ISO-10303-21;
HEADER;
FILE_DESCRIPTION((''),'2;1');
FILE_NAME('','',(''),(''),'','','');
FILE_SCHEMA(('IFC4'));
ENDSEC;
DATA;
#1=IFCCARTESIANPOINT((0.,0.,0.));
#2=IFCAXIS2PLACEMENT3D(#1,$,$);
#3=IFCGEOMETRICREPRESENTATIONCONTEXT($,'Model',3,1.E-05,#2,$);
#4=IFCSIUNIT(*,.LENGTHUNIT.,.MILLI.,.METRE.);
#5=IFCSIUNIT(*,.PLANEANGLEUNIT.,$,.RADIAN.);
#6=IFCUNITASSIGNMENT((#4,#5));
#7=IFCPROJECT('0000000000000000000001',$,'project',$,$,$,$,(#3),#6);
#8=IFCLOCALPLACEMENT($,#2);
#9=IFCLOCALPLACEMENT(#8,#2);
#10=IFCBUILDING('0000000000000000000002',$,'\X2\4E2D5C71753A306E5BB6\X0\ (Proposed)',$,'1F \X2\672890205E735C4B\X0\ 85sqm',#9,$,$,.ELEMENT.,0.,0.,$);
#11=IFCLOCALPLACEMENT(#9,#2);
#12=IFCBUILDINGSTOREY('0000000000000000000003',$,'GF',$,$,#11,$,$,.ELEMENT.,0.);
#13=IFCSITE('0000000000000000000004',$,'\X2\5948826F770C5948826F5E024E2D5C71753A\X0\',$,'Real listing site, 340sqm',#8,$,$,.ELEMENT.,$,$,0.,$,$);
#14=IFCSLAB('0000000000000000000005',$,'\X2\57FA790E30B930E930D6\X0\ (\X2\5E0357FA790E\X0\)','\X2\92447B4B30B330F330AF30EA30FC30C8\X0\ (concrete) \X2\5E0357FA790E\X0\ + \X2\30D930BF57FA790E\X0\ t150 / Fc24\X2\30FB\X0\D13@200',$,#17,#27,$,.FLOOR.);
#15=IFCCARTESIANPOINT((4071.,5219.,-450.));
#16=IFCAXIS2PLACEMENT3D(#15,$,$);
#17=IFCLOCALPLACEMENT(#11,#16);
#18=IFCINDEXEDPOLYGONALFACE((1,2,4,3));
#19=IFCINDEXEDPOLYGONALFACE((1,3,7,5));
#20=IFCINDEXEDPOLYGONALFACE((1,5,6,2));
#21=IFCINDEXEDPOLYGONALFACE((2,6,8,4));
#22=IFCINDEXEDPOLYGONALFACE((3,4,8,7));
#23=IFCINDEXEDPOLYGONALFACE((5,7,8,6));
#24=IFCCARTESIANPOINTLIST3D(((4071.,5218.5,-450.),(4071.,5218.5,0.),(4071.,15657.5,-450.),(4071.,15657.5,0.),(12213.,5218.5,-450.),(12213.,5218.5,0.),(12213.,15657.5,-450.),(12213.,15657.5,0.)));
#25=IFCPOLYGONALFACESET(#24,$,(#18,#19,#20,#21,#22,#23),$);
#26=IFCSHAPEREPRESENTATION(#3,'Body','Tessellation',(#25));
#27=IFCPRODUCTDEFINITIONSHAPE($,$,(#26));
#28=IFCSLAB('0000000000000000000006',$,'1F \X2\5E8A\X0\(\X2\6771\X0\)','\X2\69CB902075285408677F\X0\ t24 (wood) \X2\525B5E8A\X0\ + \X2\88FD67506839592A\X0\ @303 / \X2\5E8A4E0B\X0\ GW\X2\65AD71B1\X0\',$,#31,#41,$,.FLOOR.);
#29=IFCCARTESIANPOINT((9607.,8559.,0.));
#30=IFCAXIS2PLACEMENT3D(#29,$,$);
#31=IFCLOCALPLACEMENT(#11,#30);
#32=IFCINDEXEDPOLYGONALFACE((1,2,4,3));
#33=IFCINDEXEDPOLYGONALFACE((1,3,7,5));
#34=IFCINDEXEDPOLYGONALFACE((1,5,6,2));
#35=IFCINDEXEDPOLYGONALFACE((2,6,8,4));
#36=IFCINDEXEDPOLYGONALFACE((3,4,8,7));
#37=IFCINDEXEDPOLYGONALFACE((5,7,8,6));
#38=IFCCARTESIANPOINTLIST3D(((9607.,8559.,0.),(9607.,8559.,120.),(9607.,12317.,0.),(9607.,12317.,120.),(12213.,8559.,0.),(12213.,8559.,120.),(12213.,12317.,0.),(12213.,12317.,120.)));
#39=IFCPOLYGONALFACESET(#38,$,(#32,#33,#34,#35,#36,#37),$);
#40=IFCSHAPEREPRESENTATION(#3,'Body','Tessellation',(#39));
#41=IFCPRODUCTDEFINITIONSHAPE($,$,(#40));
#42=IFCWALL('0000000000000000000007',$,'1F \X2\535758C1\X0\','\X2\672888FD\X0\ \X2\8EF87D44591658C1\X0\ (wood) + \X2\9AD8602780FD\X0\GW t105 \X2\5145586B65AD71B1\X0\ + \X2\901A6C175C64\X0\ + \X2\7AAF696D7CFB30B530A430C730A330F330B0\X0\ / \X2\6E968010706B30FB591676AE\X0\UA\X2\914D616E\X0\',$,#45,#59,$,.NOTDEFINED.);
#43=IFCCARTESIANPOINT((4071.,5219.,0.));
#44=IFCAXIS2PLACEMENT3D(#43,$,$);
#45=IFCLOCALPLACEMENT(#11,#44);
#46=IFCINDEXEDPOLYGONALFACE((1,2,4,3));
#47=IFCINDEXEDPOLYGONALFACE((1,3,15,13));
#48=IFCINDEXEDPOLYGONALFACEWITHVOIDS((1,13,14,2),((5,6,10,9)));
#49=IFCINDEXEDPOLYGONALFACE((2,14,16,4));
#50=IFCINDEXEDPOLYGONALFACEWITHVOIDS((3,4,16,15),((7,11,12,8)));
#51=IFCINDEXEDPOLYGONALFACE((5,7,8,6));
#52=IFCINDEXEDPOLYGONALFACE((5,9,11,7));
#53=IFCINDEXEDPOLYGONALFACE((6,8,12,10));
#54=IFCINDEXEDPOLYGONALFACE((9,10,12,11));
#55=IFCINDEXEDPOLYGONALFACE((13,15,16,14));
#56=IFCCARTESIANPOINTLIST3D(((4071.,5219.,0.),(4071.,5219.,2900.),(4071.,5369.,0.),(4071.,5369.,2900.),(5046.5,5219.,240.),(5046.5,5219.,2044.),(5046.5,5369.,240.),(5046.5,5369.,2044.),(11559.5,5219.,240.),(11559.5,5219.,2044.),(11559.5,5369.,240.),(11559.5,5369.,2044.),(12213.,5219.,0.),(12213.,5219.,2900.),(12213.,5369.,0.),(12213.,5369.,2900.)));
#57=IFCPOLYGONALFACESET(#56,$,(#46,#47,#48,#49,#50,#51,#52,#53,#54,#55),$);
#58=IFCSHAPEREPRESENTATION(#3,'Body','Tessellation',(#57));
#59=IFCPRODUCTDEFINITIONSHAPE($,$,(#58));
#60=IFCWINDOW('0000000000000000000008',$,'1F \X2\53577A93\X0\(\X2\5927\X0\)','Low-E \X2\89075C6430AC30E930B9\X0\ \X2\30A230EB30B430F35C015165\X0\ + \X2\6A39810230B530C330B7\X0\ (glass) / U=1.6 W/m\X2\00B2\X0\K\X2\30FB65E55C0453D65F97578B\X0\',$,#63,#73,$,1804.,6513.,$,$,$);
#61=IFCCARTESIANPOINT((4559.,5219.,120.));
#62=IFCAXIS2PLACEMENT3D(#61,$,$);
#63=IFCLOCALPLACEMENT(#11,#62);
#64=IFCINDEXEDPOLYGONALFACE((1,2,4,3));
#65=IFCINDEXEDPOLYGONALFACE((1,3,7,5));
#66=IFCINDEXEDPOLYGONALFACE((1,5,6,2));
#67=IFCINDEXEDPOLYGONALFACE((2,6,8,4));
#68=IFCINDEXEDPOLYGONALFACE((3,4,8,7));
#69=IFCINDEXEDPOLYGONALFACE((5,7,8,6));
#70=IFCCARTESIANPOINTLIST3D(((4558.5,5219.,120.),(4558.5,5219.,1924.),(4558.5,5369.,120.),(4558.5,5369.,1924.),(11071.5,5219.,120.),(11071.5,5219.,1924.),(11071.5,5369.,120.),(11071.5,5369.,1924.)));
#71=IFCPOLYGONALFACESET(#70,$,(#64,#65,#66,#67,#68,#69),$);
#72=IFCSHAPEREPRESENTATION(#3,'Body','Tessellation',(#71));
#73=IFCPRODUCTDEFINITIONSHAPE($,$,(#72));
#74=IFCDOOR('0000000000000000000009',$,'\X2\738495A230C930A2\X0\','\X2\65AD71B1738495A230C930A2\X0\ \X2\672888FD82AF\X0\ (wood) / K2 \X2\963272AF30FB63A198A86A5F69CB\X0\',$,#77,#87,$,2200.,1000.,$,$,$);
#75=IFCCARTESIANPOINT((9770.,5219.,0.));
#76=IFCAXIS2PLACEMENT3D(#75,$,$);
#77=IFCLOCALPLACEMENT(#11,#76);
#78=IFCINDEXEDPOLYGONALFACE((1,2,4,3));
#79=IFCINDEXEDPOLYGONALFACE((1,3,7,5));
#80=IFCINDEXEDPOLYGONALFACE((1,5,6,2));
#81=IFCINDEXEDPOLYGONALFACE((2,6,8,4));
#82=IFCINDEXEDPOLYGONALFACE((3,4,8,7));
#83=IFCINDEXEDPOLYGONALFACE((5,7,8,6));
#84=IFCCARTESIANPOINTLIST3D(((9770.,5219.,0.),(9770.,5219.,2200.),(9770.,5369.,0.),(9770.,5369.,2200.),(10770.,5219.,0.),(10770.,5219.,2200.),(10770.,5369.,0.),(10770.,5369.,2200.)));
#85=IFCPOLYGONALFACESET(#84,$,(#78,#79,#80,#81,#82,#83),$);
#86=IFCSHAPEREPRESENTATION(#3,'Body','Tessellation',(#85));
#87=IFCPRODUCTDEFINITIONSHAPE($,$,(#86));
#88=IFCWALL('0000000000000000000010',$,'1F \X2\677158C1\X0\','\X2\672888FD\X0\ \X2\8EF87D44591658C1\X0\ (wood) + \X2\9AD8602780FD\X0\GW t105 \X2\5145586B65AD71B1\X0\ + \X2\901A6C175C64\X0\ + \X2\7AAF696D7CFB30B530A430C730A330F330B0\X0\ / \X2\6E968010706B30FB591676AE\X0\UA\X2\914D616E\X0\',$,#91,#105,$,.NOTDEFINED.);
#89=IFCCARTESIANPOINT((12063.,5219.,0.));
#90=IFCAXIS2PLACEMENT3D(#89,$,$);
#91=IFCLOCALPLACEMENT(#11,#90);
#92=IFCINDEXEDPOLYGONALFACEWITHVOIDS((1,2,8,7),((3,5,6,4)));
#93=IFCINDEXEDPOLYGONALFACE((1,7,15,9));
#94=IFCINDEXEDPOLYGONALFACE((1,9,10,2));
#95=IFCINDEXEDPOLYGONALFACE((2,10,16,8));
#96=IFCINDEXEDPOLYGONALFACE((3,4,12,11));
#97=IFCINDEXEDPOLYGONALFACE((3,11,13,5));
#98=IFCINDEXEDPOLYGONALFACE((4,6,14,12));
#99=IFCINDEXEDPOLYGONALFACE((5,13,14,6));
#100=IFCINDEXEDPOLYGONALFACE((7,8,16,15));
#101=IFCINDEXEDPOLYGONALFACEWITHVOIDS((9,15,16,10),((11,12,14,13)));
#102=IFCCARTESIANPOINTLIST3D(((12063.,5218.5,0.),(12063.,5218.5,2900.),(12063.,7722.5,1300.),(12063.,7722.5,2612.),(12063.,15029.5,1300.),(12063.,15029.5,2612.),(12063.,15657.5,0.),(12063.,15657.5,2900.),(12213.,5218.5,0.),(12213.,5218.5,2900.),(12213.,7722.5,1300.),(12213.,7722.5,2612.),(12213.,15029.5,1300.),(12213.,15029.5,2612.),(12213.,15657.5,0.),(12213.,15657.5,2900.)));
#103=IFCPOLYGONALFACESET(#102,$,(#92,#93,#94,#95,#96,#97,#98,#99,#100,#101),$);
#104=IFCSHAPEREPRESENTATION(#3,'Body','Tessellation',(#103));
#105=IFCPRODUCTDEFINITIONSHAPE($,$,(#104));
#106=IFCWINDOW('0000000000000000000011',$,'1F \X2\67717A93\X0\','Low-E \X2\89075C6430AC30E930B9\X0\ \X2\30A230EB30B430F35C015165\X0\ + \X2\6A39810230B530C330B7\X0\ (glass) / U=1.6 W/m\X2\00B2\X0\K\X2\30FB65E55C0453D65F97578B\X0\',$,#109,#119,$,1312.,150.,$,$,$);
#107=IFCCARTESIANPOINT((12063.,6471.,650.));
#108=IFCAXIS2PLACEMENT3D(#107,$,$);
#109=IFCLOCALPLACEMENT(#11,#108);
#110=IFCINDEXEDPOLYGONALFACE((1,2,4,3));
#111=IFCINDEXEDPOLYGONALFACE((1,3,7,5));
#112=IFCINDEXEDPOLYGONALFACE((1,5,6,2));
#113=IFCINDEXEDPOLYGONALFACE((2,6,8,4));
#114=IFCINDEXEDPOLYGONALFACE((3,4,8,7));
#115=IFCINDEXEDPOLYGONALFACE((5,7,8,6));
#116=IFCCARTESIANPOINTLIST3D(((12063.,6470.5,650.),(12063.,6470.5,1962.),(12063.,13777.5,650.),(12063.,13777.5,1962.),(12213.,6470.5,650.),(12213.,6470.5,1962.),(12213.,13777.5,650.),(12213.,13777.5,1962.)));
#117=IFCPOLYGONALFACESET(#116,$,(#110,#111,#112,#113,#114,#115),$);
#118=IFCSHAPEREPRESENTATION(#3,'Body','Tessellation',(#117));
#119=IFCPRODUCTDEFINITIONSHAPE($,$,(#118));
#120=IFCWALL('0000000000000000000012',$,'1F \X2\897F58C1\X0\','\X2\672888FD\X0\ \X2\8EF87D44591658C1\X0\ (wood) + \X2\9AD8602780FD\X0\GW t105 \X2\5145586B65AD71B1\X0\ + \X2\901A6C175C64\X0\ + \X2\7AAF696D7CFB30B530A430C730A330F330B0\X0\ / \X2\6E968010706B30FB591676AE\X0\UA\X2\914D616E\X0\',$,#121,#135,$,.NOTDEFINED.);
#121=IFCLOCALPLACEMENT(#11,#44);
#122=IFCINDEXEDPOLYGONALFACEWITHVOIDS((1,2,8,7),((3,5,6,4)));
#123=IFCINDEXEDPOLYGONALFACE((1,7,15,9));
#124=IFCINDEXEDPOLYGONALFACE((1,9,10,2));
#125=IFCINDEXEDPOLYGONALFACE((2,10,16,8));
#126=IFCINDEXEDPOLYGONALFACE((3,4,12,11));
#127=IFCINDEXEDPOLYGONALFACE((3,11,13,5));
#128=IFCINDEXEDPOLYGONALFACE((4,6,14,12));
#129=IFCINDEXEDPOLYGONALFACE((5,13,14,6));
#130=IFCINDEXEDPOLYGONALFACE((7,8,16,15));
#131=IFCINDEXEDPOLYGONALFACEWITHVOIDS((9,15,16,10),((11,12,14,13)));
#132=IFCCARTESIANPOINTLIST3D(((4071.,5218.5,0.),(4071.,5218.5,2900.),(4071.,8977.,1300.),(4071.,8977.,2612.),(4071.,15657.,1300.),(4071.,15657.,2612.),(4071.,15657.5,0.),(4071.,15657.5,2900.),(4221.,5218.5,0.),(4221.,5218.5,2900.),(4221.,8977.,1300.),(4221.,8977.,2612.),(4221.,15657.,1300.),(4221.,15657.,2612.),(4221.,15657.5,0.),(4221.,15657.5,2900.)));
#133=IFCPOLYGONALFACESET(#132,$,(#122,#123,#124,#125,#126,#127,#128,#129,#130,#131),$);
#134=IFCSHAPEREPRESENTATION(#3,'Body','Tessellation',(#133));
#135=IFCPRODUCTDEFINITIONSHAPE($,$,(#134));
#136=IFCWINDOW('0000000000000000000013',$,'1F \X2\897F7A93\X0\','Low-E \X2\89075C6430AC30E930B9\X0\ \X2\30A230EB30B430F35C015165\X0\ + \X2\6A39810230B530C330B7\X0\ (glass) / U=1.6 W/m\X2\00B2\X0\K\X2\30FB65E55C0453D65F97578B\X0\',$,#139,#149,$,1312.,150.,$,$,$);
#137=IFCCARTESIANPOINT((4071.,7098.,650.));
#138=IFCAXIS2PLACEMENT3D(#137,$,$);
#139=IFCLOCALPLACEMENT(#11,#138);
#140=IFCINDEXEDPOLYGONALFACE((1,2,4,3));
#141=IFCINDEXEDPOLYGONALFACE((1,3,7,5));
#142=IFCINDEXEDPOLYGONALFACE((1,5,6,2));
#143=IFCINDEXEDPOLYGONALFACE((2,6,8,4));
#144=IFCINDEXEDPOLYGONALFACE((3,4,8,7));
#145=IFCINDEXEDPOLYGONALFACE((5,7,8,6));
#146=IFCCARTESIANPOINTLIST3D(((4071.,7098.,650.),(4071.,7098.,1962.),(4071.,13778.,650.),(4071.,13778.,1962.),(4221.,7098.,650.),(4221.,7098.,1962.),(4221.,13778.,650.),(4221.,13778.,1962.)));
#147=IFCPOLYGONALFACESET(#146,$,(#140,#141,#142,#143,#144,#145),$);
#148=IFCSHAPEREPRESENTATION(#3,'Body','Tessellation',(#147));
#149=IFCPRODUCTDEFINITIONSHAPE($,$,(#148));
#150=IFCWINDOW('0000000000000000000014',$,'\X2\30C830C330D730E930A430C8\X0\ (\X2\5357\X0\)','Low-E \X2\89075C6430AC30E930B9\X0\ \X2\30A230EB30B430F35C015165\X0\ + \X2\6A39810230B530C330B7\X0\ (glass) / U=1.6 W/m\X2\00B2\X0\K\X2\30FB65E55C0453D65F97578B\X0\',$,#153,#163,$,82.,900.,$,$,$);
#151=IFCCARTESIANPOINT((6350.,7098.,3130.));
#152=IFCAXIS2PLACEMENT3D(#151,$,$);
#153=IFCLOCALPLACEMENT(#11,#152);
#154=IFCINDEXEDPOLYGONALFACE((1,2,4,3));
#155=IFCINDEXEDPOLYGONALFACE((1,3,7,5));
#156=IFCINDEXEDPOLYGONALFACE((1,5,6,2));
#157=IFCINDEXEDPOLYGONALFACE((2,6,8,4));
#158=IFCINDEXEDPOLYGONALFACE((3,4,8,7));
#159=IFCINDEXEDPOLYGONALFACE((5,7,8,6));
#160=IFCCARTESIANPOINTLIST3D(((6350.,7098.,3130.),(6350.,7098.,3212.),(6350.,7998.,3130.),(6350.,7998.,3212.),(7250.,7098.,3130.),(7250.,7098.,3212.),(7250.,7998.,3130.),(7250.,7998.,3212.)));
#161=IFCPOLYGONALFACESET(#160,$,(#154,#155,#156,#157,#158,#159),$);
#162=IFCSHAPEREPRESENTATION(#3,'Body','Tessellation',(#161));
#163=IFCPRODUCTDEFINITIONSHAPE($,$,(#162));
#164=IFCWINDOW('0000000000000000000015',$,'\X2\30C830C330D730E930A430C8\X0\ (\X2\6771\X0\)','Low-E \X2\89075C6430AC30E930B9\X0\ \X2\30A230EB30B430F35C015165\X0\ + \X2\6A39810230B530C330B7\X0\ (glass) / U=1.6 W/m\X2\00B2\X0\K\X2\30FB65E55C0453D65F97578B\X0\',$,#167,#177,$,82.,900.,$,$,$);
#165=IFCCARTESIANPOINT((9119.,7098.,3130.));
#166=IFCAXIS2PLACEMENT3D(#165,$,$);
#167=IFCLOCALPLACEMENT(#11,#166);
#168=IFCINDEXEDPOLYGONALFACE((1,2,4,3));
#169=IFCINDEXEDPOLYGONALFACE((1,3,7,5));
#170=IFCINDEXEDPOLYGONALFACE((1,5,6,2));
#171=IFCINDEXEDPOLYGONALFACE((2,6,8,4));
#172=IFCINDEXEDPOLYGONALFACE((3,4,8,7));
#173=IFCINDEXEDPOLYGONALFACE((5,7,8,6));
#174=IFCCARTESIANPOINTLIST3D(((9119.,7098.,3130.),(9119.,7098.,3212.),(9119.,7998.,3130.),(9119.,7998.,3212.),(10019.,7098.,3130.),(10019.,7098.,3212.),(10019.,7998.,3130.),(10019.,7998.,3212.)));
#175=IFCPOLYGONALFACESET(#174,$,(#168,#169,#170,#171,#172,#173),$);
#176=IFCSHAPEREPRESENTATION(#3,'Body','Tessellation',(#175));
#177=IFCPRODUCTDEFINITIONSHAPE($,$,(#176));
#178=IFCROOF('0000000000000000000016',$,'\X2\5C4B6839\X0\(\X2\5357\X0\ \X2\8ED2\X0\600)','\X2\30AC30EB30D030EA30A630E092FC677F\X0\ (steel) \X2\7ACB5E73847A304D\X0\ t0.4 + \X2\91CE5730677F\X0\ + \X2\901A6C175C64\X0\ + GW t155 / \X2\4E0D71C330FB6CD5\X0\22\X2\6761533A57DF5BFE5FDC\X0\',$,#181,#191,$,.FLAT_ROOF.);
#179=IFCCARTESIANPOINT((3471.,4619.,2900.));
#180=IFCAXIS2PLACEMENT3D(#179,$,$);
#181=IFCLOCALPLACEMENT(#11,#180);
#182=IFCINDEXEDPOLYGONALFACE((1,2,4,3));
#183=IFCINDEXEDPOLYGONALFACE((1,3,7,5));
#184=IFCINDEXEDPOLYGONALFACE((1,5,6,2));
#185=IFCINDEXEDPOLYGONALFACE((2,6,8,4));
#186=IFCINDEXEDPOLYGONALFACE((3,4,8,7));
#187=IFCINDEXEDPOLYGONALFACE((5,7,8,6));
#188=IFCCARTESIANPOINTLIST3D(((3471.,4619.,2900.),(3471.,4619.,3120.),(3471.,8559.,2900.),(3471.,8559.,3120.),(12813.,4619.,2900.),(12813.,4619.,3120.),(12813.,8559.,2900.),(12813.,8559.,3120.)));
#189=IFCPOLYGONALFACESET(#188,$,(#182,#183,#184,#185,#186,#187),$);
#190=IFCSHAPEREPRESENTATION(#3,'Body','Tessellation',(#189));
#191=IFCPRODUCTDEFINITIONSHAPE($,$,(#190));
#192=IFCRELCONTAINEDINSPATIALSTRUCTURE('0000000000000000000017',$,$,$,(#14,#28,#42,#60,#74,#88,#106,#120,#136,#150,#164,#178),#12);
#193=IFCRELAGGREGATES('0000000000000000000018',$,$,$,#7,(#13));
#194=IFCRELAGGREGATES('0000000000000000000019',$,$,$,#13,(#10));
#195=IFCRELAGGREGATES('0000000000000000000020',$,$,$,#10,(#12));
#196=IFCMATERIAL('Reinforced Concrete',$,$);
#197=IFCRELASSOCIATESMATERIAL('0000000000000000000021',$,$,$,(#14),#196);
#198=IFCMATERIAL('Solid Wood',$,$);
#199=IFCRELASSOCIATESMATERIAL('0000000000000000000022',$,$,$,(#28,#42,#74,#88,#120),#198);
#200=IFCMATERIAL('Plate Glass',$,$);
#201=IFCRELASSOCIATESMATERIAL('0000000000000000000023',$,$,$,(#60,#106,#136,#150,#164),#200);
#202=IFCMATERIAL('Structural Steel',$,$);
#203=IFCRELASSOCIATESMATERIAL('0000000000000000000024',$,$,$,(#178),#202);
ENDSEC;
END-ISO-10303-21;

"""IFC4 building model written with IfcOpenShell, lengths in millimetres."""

from ifc_helpers import new_model, si_unit, frame, frame_2d, origin, place, context, project, spatial, rectangle, extrude, material, element, fill, save


model = new_model("IFC4")

# Units and contexts
model_context = context("Model", 3, precision=1e-05, world=origin())
ifc_project = project(units=[si_unit("LENGTHUNIT", "METRE", prefix="MILLI"), si_unit("PLANEANGLEUNIT", "RADIAN")], contexts=[model_context])

# Site, building, storey
site_placement = place(None, origin())
site = spatial("IfcSite", under=ifc_project, at=site_placement, Name="奈良県奈良市中山町", ObjectType="Real listing site, 340sqm", CompositionType="ELEMENT", RefElevation=0.0)
building_placement = place(site_placement, origin())
building = spatial("IfcBuilding", under=site, at=building_placement, Name="中山町の家 (Proposed)", ObjectType="1F 木造平屋 85sqm", CompositionType="ELEMENT", ElevationOfRefHeight=0.0, ElevationOfTerrain=0.0)
storey_placement = place(building_placement, origin())
storey = spatial("IfcBuildingStorey", under=building, at=storey_placement, Name="GF", CompositionType="ELEMENT", Elevation=0.0)

# Slabs
ifc_material_1 = material(Name="Reinforced Concrete")
slab_1_placement = place(storey_placement, frame((4071.0, 5219.0, -450.0)))
element("IfcSlab", 1, at=slab_1_placement, inside=storey, material=ifc_material_1, Name="基礎スラブ (布基礎)", Description="鉄筋コンクリート (concrete) 布基礎 + ベタ基礎 t150 / Fc24・D13@200", PredefinedType="FLOOR", context=model_context, shape_type="SweptSolid", body=[
    extrude(rectangle(XDim=8142.0, YDim=10439.0, at=frame_2d((4071.0, 5219.0))), frame((4071.0, 5219.0, -450.0)), (0.0, 0.0, 1.0), 450.0),
])
ifc_material_2 = material(Name="Solid Wood")
slab_2_placement = place(storey_placement, frame((9607.0, 8559.0, 0.0)))
element("IfcSlab", 2, at=slab_2_placement, inside=storey, material=ifc_material_2, Name="1F 床(東)", Description="構造用合板 t24 (wood) 剛床 + 製材根太 @303 / 床下 GW断熱", PredefinedType="FLOOR", context=model_context, shape_type="SweptSolid", body=[
    extrude(rectangle(XDim=2606.0, YDim=3758.0, at=frame_2d((1303.0, 1879.0))), frame((9607.0, 8559.0, 0.0)), (0.0, 0.0, 1.0), 120.0),
])

# Wall, openings, window, door
wall_1_placement = place(storey_placement, frame((4071.0, 5219.0, 0.0)))
wall_1 = element("IfcWall", 3, at=wall_1_placement, inside=storey, material=ifc_material_2, Name="1F 南壁", Description="木製 軸組外壁 (wood) + 高性能GW t105 充填断熱 + 通気層 + 窯業系サイディング / 準耐火・外皮UA配慮", PredefinedType="NOTDEFINED", context=model_context, shape_type="SweptSolid", body=[
    extrude(rectangle(XDim=8142.0, YDim=150.0, at=frame_2d((4071.0, 75.0))), frame((4071.0, 5219.0, 0.0)), (0.0, 0.0, 1.0), 2900.0),
])
opening_1_placement = place(storey_placement, frame((4559.0, 5219.0, 120.0)))
opening_1 = element("IfcOpeningElement", 4, at=opening_1_placement, cuts=wall_1, PredefinedType="NOTDEFINED", context=model_context, shape_type="SweptSolid", body=[
    extrude(rectangle(XDim=6513.0, YDim=150.0, at=frame_2d((3256.0, 75.0))), frame((4559.0, 5219.0, 120.0)), (0.0, 0.0, 1.0), 1804.0),
])
opening_2_placement = place(storey_placement, frame((9770.0, 5219.0, 0.0)))
opening_2 = element("IfcOpeningElement", 5, at=opening_2_placement, cuts=wall_1, PredefinedType="NOTDEFINED", context=model_context, shape_type="SweptSolid", body=[
    extrude(rectangle(XDim=1000.0, YDim=150.0, at=frame_2d((500.0, 75.0))), frame((9770.0, 5219.0, 0.0)), (0.0, 0.0, 1.0), 2200.0),
])
ifc_material_3 = material(Name="Plate Glass")
window_1_placement = place(storey_placement, frame((4559.0, 5219.0, 120.0)))
window_1 = element("IfcWindow", 6, at=window_1_placement, inside=storey, material=ifc_material_3, Name="1F 南窓(大)", Description="Low-E 複層ガラス アルゴン封入 + 樹脂サッシ (glass) / U=1.6 W/m²K・日射取得型", OverallHeight=1804.0, OverallWidth=6513.0, context=model_context, shape_type="SweptSolid", body=[
    extrude(rectangle(XDim=6513.0, YDim=150.0, at=frame_2d((3256.0, 75.0))), frame((4559.0, 5219.0, 120.0)), (0.0, 0.0, 1.0), 1804.0),
])
fill(opening_1, window_1)
door_placement = place(storey_placement, frame((9770.0, 5219.0, 0.0)))
door = element("IfcDoor", 7, at=door_placement, inside=storey, material=ifc_material_2, Name="玄関ドア", Description="断熱玄関ドア 木製芯 (wood) / K2 防犯・採風機構", OverallHeight=2200.0, OverallWidth=1000.0, context=model_context, shape_type="SweptSolid", body=[
    extrude(rectangle(XDim=1000.0, YDim=150.0, at=frame_2d((500.0, 75.0))), frame((9770.0, 5219.0, 0.0)), (0.0, 0.0, 1.0), 2200.0),
])
fill(opening_2, door)

# Walls, openings, windows
wall_2_placement = place(storey_placement, frame((12063.0, 5219.0, 0.0)))
wall_2 = element("IfcWall", 8, at=wall_2_placement, inside=storey, material=ifc_material_2, Name="1F 東壁", Description="木製 軸組外壁 (wood) + 高性能GW t105 充填断熱 + 通気層 + 窯業系サイディング / 準耐火・外皮UA配慮", PredefinedType="NOTDEFINED", context=model_context, shape_type="SweptSolid", body=[
    extrude(rectangle(XDim=150.0, YDim=10439.0, at=frame_2d((75.0, 5219.0))), frame((12063.0, 5219.0, 0.0)), (0.0, 0.0, 1.0), 2900.0),
])
opening_3_placement = place(storey_placement, frame((12063.0, 6471.0, 650.0)))
opening_3 = element("IfcOpeningElement", 9, at=opening_3_placement, cuts=wall_2, PredefinedType="NOTDEFINED", context=model_context, shape_type="SweptSolid", body=[
    extrude(rectangle(XDim=150.0, YDim=7307.0, at=frame_2d((75.0, 3653.0))), frame((12063.0, 6471.0, 650.0)), (0.0, 0.0, 1.0), 1312.0),
])
window_2_placement = place(storey_placement, frame((12063.0, 6471.0, 650.0)))
window_2 = element("IfcWindow", 10, at=window_2_placement, inside=storey, material=ifc_material_3, Name="1F 東窓", Description="Low-E 複層ガラス アルゴン封入 + 樹脂サッシ (glass) / U=1.6 W/m²K・日射取得型", OverallHeight=1312.0, OverallWidth=150.0, context=model_context, shape_type="SweptSolid", body=[
    extrude(rectangle(XDim=150.0, YDim=7307.0, at=frame_2d((75.0, 3653.0))), frame((12063.0, 6471.0, 650.0)), (0.0, 0.0, 1.0), 1312.0),
])
fill(opening_3, window_2)
wall_3_placement = place(storey_placement, frame((4071.0, 5219.0, 0.0)))
wall_3 = element("IfcWall", 11, at=wall_3_placement, inside=storey, material=ifc_material_2, Name="1F 西壁", Description="木製 軸組外壁 (wood) + 高性能GW t105 充填断熱 + 通気層 + 窯業系サイディング / 準耐火・外皮UA配慮", PredefinedType="NOTDEFINED", context=model_context, shape_type="SweptSolid", body=[
    extrude(rectangle(XDim=150.0, YDim=10439.0, at=frame_2d((75.0, 5219.0))), frame((4071.0, 5219.0, 0.0)), (0.0, 0.0, 1.0), 2900.0),
])
opening_4_placement = place(storey_placement, frame((4071.0, 7098.0, 650.0)))
opening_4 = element("IfcOpeningElement", 12, at=opening_4_placement, cuts=wall_3, PredefinedType="NOTDEFINED", context=model_context, shape_type="SweptSolid", body=[
    extrude(rectangle(XDim=150.0, YDim=6680.0, at=frame_2d((75.0, 3340.0))), frame((4071.0, 7098.0, 650.0)), (0.0, 0.0, 1.0), 1312.0),
])
window_3_placement = place(storey_placement, frame((4071.0, 7098.0, 650.0)))
window_3 = element("IfcWindow", 13, at=window_3_placement, inside=storey, material=ifc_material_3, Name="1F 西窓", Description="Low-E 複層ガラス アルゴン封入 + 樹脂サッシ (glass) / U=1.6 W/m²K・日射取得型", OverallHeight=1312.0, OverallWidth=150.0, context=model_context, shape_type="SweptSolid", body=[
    extrude(rectangle(XDim=150.0, YDim=6680.0, at=frame_2d((75.0, 3340.0))), frame((4071.0, 7098.0, 650.0)), (0.0, 0.0, 1.0), 1312.0),
])
fill(opening_4, window_3)

# Windows
window_4_placement = place(storey_placement, frame((6350.0, 7098.0, 3130.0)))
element("IfcWindow", 14, at=window_4_placement, inside=storey, material=ifc_material_3, Name="トップライト (南)", Description="Low-E 複層ガラス アルゴン封入 + 樹脂サッシ (glass) / U=1.6 W/m²K・日射取得型", OverallHeight=82.0, OverallWidth=900.0, context=model_context, shape_type="SweptSolid", body=[
    extrude(rectangle(XDim=900.0, YDim=900.0, at=frame_2d((450.0, 450.0))), frame((6350.0, 7098.0, 3130.0)), (0.0, 0.0, 1.0), 82.0),
])
window_5_placement = place(storey_placement, frame((9119.0, 7098.0, 3130.0)))
element("IfcWindow", 15, at=window_5_placement, inside=storey, material=ifc_material_3, Name="トップライト (東)", Description="Low-E 複層ガラス アルゴン封入 + 樹脂サッシ (glass) / U=1.6 W/m²K・日射取得型", OverallHeight=82.0, OverallWidth=900.0, context=model_context, shape_type="SweptSolid", body=[
    extrude(rectangle(XDim=900.0, YDim=900.0, at=frame_2d((450.0, 450.0))), frame((9119.0, 7098.0, 3130.0)), (0.0, 0.0, 1.0), 82.0),
])

# Roof
ifc_material_4 = material(Name="Structural Steel")
roof_placement = place(storey_placement, frame((3471.0, 4619.0, 2900.0)))
element("IfcRoof", 16, at=roof_placement, inside=storey, material=ifc_material_4, Name="屋根(南 軒600)", Description="ガルバリウム鋼板 (steel) 立平葺き t0.4 + 野地板 + 通気層 + GW t155 / 不燃・法22条区域対応", PredefinedType="FLAT_ROOF", context=model_context, shape_type="SweptSolid", body=[
    extrude(rectangle(XDim=9342.0, YDim=3940.0, at=frame_2d((4671.0, 1970.0))), frame((3471.0, 4619.0, 2900.0)), (0.0, 0.0, 1.0), 220.0),
])

save(model, "model.ifc")
